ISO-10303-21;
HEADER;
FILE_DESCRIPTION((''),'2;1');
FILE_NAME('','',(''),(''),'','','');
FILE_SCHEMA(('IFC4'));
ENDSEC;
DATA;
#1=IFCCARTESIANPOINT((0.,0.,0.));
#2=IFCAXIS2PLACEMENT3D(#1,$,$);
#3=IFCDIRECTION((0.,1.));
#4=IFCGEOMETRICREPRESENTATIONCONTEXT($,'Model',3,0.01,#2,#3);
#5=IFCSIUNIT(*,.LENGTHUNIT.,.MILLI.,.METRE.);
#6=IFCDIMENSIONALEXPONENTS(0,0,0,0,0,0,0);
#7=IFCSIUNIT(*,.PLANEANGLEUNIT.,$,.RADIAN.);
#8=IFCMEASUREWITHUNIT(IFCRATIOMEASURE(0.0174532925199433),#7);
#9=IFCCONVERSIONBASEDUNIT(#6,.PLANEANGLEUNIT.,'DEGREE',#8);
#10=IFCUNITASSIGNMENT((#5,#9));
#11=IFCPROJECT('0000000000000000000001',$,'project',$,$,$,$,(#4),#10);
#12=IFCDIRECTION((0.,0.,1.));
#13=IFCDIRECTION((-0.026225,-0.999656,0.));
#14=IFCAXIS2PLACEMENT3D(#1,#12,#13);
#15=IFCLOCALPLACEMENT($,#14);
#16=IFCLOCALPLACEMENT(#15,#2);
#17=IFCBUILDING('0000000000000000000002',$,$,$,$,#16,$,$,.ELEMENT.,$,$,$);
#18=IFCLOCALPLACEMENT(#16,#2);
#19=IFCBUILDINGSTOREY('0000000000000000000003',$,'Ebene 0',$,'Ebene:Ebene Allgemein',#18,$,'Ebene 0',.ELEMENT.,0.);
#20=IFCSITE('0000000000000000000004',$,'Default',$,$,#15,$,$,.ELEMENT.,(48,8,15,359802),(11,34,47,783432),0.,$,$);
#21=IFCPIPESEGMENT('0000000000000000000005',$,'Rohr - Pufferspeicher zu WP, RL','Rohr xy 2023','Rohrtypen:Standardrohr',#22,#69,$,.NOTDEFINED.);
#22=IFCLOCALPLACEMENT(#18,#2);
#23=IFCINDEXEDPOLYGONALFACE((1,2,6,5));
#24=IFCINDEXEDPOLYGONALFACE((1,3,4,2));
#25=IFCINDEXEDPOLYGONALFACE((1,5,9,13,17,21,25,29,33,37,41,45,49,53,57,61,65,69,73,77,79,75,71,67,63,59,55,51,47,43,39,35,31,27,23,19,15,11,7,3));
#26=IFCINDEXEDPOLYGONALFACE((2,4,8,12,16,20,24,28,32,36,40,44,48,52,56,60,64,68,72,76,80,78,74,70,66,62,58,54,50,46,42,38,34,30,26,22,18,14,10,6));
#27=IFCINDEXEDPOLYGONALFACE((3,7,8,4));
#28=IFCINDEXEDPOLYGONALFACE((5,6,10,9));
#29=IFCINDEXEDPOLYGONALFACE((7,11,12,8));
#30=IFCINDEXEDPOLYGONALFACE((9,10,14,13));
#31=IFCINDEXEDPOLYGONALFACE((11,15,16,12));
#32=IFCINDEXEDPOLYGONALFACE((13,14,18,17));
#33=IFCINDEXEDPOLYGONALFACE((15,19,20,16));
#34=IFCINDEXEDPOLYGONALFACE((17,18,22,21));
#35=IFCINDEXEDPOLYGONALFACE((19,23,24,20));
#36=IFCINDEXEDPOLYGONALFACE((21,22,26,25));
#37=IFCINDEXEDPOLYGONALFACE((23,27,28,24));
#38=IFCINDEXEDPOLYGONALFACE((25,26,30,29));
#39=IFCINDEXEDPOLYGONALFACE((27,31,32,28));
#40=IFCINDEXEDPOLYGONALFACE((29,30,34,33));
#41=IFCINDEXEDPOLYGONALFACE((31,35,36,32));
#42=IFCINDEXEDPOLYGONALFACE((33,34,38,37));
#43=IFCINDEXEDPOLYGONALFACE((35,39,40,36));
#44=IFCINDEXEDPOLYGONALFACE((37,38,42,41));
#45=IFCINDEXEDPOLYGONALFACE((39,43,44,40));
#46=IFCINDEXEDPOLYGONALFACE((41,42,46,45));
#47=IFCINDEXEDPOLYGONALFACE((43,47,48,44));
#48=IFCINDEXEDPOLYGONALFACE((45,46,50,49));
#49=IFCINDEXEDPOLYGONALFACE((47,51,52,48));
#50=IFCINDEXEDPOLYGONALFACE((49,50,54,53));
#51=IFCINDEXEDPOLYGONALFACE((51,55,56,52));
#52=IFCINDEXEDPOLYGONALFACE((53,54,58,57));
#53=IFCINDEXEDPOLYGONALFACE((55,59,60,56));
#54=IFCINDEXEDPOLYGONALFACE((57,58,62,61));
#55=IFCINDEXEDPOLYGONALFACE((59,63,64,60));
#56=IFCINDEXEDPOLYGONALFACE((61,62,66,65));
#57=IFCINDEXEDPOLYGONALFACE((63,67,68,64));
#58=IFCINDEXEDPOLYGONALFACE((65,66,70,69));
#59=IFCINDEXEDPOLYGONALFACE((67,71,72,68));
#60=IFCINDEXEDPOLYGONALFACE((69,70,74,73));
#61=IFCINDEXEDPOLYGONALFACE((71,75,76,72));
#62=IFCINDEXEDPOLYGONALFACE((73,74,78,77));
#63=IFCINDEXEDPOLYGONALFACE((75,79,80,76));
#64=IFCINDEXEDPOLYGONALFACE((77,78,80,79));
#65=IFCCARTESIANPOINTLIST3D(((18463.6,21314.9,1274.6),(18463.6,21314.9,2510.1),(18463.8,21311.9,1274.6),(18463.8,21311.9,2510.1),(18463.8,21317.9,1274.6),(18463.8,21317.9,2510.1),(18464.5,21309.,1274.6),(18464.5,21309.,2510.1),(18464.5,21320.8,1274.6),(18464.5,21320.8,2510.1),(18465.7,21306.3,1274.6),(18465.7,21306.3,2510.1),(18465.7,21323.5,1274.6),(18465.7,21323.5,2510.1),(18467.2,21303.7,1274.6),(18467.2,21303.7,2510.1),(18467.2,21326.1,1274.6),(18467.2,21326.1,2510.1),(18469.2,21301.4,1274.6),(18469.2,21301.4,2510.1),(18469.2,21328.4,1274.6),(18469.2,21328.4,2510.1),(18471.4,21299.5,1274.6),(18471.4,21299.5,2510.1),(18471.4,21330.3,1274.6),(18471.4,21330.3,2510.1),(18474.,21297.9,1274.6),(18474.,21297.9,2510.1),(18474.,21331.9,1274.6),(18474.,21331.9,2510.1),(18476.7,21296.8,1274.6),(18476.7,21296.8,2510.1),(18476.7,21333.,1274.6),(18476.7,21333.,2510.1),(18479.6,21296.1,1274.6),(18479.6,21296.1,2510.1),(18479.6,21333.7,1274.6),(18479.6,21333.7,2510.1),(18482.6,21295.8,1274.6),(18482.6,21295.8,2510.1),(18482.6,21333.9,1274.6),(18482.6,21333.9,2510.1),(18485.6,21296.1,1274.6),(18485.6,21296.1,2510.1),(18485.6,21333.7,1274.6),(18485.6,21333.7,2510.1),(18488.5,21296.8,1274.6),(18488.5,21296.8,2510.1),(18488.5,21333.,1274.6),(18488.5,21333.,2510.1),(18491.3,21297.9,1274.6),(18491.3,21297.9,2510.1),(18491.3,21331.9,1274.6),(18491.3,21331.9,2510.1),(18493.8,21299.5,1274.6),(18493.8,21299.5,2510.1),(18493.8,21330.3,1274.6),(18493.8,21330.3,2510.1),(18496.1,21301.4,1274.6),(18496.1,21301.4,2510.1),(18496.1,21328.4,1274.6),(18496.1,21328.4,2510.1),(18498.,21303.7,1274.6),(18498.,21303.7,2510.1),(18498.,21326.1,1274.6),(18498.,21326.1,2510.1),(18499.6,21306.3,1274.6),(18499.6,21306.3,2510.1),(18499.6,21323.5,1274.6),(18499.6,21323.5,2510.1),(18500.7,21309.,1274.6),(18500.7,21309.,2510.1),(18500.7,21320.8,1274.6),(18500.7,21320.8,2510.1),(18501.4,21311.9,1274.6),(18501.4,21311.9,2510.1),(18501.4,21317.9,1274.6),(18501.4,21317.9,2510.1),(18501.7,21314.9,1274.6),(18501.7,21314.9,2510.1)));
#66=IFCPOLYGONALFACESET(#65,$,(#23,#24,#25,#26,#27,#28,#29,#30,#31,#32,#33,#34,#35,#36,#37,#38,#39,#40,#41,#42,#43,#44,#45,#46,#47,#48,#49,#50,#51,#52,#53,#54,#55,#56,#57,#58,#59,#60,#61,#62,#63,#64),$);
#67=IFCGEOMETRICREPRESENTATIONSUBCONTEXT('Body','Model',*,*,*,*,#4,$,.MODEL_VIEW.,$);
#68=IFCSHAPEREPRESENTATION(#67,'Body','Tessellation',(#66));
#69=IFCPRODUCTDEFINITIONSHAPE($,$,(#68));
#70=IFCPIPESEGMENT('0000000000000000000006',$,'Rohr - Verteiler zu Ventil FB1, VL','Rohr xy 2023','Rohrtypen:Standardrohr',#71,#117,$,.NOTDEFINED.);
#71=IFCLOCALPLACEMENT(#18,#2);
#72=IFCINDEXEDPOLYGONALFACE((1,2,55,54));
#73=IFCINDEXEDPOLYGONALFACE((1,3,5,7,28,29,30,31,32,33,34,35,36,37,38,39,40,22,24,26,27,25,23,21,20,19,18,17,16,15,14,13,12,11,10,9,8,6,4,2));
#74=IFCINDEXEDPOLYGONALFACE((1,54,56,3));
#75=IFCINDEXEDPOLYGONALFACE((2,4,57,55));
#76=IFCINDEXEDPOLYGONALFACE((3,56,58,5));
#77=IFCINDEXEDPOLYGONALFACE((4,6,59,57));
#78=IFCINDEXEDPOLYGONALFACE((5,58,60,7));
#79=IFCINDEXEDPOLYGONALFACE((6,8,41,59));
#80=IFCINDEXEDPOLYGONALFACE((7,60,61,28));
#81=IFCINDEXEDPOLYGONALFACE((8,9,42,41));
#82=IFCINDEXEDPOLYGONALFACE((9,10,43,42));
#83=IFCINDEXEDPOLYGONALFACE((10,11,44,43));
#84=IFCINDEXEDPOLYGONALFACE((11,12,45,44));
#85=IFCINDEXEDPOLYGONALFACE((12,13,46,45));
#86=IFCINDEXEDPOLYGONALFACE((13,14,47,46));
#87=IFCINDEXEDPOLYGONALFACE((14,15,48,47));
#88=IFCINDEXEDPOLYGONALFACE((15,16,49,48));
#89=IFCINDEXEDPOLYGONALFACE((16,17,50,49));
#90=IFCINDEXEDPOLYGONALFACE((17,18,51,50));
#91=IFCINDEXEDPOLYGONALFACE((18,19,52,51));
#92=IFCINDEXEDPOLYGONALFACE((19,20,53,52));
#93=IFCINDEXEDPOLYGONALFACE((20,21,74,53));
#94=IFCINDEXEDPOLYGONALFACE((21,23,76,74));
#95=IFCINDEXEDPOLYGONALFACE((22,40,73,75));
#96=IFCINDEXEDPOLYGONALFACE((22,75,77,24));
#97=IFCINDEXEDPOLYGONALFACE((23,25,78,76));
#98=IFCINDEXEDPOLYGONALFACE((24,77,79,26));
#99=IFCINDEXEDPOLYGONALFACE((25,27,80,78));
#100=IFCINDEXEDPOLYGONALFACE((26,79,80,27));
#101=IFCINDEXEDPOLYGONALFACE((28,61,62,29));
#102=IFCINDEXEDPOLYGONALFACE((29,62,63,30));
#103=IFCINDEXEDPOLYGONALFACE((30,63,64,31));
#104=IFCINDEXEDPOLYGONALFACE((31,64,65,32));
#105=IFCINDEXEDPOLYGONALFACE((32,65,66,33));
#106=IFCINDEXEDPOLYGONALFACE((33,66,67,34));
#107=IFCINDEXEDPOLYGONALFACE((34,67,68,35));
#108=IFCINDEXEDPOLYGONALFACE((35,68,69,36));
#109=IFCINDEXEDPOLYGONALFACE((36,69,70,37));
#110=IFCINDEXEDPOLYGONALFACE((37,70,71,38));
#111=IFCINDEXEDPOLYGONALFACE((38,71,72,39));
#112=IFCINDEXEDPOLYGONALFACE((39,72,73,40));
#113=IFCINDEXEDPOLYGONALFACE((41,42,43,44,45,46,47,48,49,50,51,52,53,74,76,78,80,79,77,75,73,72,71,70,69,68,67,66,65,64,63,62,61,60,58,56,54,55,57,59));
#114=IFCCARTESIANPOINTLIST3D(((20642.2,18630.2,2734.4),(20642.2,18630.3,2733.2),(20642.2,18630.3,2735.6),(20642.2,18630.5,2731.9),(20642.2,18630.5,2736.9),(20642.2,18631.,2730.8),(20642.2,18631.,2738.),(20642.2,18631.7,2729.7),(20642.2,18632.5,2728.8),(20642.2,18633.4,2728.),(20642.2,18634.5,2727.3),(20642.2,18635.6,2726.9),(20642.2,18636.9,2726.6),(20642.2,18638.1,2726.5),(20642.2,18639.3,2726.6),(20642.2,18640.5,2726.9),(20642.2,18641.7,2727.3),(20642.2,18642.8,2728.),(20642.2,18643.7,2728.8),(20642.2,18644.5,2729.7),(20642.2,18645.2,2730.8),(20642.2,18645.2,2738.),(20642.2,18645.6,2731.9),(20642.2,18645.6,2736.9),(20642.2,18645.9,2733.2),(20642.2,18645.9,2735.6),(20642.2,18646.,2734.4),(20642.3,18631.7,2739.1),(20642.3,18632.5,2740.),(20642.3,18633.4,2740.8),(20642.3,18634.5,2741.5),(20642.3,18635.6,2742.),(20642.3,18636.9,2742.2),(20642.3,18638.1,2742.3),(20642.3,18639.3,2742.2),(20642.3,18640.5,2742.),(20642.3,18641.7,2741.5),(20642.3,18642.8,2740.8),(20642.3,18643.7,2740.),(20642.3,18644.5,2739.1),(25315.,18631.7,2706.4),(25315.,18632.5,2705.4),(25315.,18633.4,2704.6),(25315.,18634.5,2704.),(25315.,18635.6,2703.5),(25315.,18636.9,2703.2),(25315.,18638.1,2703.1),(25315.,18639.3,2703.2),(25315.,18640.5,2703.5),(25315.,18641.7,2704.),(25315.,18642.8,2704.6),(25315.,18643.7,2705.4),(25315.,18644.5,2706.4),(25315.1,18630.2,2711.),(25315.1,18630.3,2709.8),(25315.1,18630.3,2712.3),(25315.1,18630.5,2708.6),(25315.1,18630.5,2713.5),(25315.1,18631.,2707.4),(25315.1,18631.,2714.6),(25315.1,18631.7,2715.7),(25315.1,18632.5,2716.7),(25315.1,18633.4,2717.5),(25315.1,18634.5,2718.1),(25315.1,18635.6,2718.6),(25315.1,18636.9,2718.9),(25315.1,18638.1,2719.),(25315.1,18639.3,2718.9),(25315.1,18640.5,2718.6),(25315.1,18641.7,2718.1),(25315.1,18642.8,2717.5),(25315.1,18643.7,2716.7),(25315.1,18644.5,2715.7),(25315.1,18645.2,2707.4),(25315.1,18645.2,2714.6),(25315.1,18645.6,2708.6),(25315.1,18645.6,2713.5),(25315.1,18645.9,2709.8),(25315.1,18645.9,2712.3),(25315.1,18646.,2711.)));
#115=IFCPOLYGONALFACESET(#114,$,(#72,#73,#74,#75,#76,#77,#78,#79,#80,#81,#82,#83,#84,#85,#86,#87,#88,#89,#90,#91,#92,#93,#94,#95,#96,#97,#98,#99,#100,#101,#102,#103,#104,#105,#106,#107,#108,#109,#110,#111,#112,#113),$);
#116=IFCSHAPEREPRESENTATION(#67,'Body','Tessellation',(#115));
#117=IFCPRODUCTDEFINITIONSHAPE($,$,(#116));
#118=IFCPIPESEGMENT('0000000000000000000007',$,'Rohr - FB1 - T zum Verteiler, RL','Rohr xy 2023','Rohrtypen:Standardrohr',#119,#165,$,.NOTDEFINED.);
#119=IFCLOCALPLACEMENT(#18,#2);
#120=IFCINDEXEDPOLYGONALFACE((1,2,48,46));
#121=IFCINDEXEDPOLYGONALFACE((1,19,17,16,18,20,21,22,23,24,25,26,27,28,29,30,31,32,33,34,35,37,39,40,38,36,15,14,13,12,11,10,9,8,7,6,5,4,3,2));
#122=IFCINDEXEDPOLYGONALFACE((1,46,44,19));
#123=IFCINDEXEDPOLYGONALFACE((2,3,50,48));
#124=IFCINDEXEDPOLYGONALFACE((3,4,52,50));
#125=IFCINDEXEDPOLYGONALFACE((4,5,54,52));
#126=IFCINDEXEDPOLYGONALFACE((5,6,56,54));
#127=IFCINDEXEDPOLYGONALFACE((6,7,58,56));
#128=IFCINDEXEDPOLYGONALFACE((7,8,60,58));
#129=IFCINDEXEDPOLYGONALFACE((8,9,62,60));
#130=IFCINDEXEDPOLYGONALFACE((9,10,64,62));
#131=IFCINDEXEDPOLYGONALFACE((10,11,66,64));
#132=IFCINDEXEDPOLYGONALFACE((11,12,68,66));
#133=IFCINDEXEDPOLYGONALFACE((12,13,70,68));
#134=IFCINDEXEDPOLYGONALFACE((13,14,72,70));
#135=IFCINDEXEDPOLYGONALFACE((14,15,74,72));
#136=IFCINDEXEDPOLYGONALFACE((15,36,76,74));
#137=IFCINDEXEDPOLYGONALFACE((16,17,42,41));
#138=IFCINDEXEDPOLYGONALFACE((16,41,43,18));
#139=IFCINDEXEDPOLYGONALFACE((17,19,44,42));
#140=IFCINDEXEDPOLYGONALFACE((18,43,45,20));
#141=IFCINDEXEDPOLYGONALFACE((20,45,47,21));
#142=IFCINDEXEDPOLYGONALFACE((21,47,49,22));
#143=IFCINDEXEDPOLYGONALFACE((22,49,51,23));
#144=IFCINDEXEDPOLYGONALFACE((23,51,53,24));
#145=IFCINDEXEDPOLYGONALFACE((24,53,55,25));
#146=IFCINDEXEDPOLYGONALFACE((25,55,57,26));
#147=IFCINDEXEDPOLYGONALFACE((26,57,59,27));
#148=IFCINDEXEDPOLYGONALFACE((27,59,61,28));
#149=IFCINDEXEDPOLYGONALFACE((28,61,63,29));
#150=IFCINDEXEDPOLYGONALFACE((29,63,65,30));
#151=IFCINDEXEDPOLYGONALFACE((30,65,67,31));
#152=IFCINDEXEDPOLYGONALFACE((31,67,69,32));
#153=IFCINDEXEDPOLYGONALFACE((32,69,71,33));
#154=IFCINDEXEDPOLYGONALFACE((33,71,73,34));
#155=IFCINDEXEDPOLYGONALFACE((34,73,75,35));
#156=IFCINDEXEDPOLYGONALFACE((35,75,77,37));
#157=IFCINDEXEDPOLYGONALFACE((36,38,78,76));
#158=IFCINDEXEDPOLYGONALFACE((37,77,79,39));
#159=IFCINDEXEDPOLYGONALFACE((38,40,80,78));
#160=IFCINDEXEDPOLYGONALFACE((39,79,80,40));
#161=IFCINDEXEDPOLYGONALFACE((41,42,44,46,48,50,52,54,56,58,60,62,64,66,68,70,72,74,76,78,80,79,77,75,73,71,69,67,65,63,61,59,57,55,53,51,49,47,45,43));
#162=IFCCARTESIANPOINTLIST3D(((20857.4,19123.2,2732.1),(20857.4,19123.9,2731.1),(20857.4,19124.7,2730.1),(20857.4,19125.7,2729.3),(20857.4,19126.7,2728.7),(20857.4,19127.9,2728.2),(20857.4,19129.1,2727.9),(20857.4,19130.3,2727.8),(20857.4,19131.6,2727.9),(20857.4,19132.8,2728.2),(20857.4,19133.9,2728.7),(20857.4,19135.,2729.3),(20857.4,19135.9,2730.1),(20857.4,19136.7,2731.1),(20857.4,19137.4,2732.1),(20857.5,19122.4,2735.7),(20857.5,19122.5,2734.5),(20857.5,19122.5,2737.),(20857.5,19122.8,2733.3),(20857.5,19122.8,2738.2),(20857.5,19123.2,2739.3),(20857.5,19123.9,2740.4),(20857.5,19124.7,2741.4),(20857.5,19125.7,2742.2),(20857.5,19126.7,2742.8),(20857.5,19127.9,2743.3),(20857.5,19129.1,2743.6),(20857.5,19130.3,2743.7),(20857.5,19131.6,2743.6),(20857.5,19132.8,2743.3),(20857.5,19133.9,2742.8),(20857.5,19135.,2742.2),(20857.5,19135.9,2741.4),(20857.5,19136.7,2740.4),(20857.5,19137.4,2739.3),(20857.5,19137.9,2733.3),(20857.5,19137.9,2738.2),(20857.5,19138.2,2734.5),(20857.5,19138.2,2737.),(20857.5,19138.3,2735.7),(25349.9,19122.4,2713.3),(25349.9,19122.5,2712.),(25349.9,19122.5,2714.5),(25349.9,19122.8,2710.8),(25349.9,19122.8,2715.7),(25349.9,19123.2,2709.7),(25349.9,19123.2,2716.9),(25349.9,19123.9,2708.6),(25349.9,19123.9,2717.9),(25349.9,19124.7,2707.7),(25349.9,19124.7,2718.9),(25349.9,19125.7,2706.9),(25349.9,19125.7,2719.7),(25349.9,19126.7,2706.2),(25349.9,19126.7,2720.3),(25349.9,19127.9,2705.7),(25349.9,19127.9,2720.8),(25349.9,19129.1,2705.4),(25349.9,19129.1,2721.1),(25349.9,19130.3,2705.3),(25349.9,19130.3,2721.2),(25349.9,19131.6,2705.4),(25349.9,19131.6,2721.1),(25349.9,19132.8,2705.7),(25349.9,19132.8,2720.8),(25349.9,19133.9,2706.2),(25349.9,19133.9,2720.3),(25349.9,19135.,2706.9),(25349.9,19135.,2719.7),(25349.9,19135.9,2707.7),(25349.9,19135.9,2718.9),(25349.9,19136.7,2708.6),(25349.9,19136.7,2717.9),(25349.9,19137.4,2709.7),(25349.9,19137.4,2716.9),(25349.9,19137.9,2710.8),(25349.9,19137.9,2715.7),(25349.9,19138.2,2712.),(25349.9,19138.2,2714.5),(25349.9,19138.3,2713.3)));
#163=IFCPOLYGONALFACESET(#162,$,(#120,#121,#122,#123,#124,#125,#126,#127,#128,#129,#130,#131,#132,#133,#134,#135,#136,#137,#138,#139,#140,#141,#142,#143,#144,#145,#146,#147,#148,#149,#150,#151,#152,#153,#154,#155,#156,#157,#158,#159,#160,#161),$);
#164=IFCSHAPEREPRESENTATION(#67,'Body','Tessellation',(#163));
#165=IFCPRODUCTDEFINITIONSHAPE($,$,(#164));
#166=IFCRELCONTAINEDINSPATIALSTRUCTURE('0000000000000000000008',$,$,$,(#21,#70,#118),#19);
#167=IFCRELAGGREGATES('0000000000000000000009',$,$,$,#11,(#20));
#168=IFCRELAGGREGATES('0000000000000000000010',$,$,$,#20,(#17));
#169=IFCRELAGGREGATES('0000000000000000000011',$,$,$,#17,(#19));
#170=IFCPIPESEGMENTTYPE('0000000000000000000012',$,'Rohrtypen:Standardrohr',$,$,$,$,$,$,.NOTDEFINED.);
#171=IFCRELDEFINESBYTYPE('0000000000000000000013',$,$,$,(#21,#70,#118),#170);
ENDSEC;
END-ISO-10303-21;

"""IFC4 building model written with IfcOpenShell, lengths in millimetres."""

from ifc_helpers import new_model, entity, si_unit, converted_unit, direction, frame, origin, place, context, subcontext, project, spatial, indexed_curve, outline, extrude, type_object, element, save


model = new_model("IFC4")

# Units and contexts
model_context = context("Model", 3, precision=0.01, world=origin(), true_north=direction((0.0, 1.0)))
body_context = subcontext(model_context, "Body", "Model", "MODEL_VIEW")
ifc_project = project(units=[si_unit("LENGTHUNIT", "METRE", prefix="MILLI"), converted_unit("PLANEANGLEUNIT", "DEGREE", entity("IfcRatioMeasure", 0.0174532925199433), si_unit("PLANEANGLEUNIT", "RADIAN"), dimensions=[0, 0, 0, 0, 0, 0, 0])], contexts=[model_context])

# Site, building, storey
site_placement = place(None, frame((0.0, 0.0, 0.0), z_axis=(0.0, 0.0, 1.0), x_axis=(-0.026225, -0.999656, 0.0)))
site = spatial("IfcSite", under=ifc_project, at=site_placement, Name="Default", CompositionType="ELEMENT", RefLatitude=(48, 8, 15, 359802), RefLongitude=(11, 34, 47, 783432), RefElevation=0.0)
building_placement = place(site_placement, origin())
building = spatial("IfcBuilding", under=site, at=building_placement, CompositionType="ELEMENT")
storey_placement = place(building_placement, origin())
storey = spatial("IfcBuildingStorey", under=building, at=storey_placement, Name="Ebene 0", ObjectType="Ebene:Ebene Allgemein", LongName="Ebene 0", CompositionType="ELEMENT", Elevation=0.0)

# Pipe segments
pipe_segment_type = type_object("IfcPipeSegmentType", Name="Rohrtypen:Standardrohr", PredefinedType="NOTDEFINED")
pipe_segment_1_placement = place(storey_placement, origin())
element("IfcPipeSegment", 1, at=pipe_segment_1_placement, inside=storey, type_object=pipe_segment_type, Name="Rohr - Pufferspeicher zu WP, RL", Description="Rohr xy 2023", ObjectType="Rohrtypen:Standardrohr", PredefinedType="NOTDEFINED", context=body_context, shape_type="SweptSolid", body=[
    extrude(outline(indexed_curve([(19.1, 0.0), (18.8, 3.0), (18.1, 5.9), (17.0, 8.6), (15.4, 11.2), (13.5, 13.5), (11.2, 15.4), (8.6, 17.0), (5.9, 18.1), (3.0, 18.8), (0.0, 19.1), (-3.0, 18.8), (-5.9, 18.1), (-8.6, 17.0), (-11.2, 15.4), (-13.5, 13.5), (-15.4, 11.2), (-17.0, 8.6), (-18.1, 5.9), (-18.8, 3.0), (-19.1, 0.0), (-18.8, -3.0), (-18.1, -5.9), (-17.0, -8.6), (-15.4, -11.2), (-13.5, -13.5), (-11.2, -15.4), (-8.6, -17.0), (-5.9, -18.1), (-3.0, -18.8), (0.0, -19.1), (3.0, -18.8), (5.9, -18.1), (8.6, -17.0), (11.2, -15.4), (13.5, -13.5), (15.4, -11.2), (17.0, -8.6), (18.1, -5.9), (18.8, -3.0), (19.1, 0.0)], self_intersect=False)), frame((18482.6, 21314.9, 1274.6), z_axis=(0.0, 0.0, 1.0), x_axis=(-1.0, 0.0, 0.0)), (0.0, 0.0, 1.0), 1235.5),
])
pipe_segment_2_placement = place(storey_placement, origin())
element("IfcPipeSegment", 2, at=pipe_segment_2_placement, inside=storey, type_object=pipe_segment_type, Name="Rohr - Verteiler zu Ventil FB1, VL", Description="Rohr xy 2023", ObjectType="Rohrtypen:Standardrohr", PredefinedType="NOTDEFINED", context=body_context, shape_type="SweptSolid", body=[
    extrude(outline(indexed_curve([(7.9, 0.0), (7.8, 1.2), (7.6, 2.5), (7.1, 3.6), (6.4, 4.7), (5.6, 5.6), (4.7, 6.4), (3.6, 7.1), (2.5, 7.6), (1.2, 7.8), (0.0, 7.9), (-1.2, 7.8), (-2.5, 7.6), (-3.6, 7.1), (-4.7, 6.4), (-5.6, 5.6), (-6.4, 4.7), (-7.1, 3.6), (-7.6, 2.5), (-7.8, 1.2), (-7.9, 0.0), (-7.8, -1.2), (-7.6, -2.5), (-7.1, -3.6), (-6.4, -4.7), (-5.6, -5.6), (-4.7, -6.4), (-3.6, -7.1), (-2.5, -7.6), (-1.2, -7.8), (0.0, -7.9), (1.2, -7.8), (2.5, -7.6), (3.6, -7.1), (4.7, -6.4), (5.6, -5.6), (6.4, -4.7), (7.1, -3.6), (7.6, -2.5), (7.8, -1.2), (7.9, 0.0)], self_intersect=False)), frame((25315.1, 18638.1, 2711.0), z_axis=(-0.999988, 0.0, 0.005), x_axis=(0.0, 1.0, 0.0)), (0.0, 0.0, 1.0), 4672.9),
])
pipe_segment_3_placement = place(storey_placement, origin())
element("IfcPipeSegment", 3, at=pipe_segment_3_placement, inside=storey, type_object=pipe_segment_type, Name="Rohr - FB1 - T zum Verteiler, RL", Description="Rohr xy 2023", ObjectType="Rohrtypen:Standardrohr", PredefinedType="NOTDEFINED", context=body_context, shape_type="SweptSolid", body=[
    extrude(outline(indexed_curve([(7.9, 0.0), (7.8, 1.2), (7.6, 2.5), (7.1, 3.6), (6.4, 4.7), (5.6, 5.6), (4.7, 6.4), (3.6, 7.1), (2.5, 7.6), (1.2, 7.8), (0.0, 7.9), (-1.2, 7.8), (-2.5, 7.6), (-3.6, 7.1), (-4.7, 6.4), (-5.6, 5.6), (-6.4, 4.7), (-7.1, 3.6), (-7.6, 2.5), (-7.8, 1.2), (-7.9, 0.0), (-7.8, -1.2), (-7.6, -2.5), (-7.1, -3.6), (-6.4, -4.7), (-5.6, -5.6), (-4.7, -6.4), (-3.6, -7.1), (-2.5, -7.6), (-1.2, -7.8), (0.0, -7.9), (1.2, -7.8), (2.5, -7.6), (3.6, -7.1), (4.7, -6.4), (5.6, -5.6), (6.4, -4.7), (7.1, -3.6), (7.6, -2.5), (7.8, -1.2), (7.9, 0.0)], self_intersect=False)), frame((25349.9, 19130.3, 2713.3), z_axis=(-0.999988, 0.0, 0.005), x_axis=(0.0, 1.0, 0.0)), (0.0, 0.0, 1.0), 4492.5),
])

save(model, "model.ifc")
